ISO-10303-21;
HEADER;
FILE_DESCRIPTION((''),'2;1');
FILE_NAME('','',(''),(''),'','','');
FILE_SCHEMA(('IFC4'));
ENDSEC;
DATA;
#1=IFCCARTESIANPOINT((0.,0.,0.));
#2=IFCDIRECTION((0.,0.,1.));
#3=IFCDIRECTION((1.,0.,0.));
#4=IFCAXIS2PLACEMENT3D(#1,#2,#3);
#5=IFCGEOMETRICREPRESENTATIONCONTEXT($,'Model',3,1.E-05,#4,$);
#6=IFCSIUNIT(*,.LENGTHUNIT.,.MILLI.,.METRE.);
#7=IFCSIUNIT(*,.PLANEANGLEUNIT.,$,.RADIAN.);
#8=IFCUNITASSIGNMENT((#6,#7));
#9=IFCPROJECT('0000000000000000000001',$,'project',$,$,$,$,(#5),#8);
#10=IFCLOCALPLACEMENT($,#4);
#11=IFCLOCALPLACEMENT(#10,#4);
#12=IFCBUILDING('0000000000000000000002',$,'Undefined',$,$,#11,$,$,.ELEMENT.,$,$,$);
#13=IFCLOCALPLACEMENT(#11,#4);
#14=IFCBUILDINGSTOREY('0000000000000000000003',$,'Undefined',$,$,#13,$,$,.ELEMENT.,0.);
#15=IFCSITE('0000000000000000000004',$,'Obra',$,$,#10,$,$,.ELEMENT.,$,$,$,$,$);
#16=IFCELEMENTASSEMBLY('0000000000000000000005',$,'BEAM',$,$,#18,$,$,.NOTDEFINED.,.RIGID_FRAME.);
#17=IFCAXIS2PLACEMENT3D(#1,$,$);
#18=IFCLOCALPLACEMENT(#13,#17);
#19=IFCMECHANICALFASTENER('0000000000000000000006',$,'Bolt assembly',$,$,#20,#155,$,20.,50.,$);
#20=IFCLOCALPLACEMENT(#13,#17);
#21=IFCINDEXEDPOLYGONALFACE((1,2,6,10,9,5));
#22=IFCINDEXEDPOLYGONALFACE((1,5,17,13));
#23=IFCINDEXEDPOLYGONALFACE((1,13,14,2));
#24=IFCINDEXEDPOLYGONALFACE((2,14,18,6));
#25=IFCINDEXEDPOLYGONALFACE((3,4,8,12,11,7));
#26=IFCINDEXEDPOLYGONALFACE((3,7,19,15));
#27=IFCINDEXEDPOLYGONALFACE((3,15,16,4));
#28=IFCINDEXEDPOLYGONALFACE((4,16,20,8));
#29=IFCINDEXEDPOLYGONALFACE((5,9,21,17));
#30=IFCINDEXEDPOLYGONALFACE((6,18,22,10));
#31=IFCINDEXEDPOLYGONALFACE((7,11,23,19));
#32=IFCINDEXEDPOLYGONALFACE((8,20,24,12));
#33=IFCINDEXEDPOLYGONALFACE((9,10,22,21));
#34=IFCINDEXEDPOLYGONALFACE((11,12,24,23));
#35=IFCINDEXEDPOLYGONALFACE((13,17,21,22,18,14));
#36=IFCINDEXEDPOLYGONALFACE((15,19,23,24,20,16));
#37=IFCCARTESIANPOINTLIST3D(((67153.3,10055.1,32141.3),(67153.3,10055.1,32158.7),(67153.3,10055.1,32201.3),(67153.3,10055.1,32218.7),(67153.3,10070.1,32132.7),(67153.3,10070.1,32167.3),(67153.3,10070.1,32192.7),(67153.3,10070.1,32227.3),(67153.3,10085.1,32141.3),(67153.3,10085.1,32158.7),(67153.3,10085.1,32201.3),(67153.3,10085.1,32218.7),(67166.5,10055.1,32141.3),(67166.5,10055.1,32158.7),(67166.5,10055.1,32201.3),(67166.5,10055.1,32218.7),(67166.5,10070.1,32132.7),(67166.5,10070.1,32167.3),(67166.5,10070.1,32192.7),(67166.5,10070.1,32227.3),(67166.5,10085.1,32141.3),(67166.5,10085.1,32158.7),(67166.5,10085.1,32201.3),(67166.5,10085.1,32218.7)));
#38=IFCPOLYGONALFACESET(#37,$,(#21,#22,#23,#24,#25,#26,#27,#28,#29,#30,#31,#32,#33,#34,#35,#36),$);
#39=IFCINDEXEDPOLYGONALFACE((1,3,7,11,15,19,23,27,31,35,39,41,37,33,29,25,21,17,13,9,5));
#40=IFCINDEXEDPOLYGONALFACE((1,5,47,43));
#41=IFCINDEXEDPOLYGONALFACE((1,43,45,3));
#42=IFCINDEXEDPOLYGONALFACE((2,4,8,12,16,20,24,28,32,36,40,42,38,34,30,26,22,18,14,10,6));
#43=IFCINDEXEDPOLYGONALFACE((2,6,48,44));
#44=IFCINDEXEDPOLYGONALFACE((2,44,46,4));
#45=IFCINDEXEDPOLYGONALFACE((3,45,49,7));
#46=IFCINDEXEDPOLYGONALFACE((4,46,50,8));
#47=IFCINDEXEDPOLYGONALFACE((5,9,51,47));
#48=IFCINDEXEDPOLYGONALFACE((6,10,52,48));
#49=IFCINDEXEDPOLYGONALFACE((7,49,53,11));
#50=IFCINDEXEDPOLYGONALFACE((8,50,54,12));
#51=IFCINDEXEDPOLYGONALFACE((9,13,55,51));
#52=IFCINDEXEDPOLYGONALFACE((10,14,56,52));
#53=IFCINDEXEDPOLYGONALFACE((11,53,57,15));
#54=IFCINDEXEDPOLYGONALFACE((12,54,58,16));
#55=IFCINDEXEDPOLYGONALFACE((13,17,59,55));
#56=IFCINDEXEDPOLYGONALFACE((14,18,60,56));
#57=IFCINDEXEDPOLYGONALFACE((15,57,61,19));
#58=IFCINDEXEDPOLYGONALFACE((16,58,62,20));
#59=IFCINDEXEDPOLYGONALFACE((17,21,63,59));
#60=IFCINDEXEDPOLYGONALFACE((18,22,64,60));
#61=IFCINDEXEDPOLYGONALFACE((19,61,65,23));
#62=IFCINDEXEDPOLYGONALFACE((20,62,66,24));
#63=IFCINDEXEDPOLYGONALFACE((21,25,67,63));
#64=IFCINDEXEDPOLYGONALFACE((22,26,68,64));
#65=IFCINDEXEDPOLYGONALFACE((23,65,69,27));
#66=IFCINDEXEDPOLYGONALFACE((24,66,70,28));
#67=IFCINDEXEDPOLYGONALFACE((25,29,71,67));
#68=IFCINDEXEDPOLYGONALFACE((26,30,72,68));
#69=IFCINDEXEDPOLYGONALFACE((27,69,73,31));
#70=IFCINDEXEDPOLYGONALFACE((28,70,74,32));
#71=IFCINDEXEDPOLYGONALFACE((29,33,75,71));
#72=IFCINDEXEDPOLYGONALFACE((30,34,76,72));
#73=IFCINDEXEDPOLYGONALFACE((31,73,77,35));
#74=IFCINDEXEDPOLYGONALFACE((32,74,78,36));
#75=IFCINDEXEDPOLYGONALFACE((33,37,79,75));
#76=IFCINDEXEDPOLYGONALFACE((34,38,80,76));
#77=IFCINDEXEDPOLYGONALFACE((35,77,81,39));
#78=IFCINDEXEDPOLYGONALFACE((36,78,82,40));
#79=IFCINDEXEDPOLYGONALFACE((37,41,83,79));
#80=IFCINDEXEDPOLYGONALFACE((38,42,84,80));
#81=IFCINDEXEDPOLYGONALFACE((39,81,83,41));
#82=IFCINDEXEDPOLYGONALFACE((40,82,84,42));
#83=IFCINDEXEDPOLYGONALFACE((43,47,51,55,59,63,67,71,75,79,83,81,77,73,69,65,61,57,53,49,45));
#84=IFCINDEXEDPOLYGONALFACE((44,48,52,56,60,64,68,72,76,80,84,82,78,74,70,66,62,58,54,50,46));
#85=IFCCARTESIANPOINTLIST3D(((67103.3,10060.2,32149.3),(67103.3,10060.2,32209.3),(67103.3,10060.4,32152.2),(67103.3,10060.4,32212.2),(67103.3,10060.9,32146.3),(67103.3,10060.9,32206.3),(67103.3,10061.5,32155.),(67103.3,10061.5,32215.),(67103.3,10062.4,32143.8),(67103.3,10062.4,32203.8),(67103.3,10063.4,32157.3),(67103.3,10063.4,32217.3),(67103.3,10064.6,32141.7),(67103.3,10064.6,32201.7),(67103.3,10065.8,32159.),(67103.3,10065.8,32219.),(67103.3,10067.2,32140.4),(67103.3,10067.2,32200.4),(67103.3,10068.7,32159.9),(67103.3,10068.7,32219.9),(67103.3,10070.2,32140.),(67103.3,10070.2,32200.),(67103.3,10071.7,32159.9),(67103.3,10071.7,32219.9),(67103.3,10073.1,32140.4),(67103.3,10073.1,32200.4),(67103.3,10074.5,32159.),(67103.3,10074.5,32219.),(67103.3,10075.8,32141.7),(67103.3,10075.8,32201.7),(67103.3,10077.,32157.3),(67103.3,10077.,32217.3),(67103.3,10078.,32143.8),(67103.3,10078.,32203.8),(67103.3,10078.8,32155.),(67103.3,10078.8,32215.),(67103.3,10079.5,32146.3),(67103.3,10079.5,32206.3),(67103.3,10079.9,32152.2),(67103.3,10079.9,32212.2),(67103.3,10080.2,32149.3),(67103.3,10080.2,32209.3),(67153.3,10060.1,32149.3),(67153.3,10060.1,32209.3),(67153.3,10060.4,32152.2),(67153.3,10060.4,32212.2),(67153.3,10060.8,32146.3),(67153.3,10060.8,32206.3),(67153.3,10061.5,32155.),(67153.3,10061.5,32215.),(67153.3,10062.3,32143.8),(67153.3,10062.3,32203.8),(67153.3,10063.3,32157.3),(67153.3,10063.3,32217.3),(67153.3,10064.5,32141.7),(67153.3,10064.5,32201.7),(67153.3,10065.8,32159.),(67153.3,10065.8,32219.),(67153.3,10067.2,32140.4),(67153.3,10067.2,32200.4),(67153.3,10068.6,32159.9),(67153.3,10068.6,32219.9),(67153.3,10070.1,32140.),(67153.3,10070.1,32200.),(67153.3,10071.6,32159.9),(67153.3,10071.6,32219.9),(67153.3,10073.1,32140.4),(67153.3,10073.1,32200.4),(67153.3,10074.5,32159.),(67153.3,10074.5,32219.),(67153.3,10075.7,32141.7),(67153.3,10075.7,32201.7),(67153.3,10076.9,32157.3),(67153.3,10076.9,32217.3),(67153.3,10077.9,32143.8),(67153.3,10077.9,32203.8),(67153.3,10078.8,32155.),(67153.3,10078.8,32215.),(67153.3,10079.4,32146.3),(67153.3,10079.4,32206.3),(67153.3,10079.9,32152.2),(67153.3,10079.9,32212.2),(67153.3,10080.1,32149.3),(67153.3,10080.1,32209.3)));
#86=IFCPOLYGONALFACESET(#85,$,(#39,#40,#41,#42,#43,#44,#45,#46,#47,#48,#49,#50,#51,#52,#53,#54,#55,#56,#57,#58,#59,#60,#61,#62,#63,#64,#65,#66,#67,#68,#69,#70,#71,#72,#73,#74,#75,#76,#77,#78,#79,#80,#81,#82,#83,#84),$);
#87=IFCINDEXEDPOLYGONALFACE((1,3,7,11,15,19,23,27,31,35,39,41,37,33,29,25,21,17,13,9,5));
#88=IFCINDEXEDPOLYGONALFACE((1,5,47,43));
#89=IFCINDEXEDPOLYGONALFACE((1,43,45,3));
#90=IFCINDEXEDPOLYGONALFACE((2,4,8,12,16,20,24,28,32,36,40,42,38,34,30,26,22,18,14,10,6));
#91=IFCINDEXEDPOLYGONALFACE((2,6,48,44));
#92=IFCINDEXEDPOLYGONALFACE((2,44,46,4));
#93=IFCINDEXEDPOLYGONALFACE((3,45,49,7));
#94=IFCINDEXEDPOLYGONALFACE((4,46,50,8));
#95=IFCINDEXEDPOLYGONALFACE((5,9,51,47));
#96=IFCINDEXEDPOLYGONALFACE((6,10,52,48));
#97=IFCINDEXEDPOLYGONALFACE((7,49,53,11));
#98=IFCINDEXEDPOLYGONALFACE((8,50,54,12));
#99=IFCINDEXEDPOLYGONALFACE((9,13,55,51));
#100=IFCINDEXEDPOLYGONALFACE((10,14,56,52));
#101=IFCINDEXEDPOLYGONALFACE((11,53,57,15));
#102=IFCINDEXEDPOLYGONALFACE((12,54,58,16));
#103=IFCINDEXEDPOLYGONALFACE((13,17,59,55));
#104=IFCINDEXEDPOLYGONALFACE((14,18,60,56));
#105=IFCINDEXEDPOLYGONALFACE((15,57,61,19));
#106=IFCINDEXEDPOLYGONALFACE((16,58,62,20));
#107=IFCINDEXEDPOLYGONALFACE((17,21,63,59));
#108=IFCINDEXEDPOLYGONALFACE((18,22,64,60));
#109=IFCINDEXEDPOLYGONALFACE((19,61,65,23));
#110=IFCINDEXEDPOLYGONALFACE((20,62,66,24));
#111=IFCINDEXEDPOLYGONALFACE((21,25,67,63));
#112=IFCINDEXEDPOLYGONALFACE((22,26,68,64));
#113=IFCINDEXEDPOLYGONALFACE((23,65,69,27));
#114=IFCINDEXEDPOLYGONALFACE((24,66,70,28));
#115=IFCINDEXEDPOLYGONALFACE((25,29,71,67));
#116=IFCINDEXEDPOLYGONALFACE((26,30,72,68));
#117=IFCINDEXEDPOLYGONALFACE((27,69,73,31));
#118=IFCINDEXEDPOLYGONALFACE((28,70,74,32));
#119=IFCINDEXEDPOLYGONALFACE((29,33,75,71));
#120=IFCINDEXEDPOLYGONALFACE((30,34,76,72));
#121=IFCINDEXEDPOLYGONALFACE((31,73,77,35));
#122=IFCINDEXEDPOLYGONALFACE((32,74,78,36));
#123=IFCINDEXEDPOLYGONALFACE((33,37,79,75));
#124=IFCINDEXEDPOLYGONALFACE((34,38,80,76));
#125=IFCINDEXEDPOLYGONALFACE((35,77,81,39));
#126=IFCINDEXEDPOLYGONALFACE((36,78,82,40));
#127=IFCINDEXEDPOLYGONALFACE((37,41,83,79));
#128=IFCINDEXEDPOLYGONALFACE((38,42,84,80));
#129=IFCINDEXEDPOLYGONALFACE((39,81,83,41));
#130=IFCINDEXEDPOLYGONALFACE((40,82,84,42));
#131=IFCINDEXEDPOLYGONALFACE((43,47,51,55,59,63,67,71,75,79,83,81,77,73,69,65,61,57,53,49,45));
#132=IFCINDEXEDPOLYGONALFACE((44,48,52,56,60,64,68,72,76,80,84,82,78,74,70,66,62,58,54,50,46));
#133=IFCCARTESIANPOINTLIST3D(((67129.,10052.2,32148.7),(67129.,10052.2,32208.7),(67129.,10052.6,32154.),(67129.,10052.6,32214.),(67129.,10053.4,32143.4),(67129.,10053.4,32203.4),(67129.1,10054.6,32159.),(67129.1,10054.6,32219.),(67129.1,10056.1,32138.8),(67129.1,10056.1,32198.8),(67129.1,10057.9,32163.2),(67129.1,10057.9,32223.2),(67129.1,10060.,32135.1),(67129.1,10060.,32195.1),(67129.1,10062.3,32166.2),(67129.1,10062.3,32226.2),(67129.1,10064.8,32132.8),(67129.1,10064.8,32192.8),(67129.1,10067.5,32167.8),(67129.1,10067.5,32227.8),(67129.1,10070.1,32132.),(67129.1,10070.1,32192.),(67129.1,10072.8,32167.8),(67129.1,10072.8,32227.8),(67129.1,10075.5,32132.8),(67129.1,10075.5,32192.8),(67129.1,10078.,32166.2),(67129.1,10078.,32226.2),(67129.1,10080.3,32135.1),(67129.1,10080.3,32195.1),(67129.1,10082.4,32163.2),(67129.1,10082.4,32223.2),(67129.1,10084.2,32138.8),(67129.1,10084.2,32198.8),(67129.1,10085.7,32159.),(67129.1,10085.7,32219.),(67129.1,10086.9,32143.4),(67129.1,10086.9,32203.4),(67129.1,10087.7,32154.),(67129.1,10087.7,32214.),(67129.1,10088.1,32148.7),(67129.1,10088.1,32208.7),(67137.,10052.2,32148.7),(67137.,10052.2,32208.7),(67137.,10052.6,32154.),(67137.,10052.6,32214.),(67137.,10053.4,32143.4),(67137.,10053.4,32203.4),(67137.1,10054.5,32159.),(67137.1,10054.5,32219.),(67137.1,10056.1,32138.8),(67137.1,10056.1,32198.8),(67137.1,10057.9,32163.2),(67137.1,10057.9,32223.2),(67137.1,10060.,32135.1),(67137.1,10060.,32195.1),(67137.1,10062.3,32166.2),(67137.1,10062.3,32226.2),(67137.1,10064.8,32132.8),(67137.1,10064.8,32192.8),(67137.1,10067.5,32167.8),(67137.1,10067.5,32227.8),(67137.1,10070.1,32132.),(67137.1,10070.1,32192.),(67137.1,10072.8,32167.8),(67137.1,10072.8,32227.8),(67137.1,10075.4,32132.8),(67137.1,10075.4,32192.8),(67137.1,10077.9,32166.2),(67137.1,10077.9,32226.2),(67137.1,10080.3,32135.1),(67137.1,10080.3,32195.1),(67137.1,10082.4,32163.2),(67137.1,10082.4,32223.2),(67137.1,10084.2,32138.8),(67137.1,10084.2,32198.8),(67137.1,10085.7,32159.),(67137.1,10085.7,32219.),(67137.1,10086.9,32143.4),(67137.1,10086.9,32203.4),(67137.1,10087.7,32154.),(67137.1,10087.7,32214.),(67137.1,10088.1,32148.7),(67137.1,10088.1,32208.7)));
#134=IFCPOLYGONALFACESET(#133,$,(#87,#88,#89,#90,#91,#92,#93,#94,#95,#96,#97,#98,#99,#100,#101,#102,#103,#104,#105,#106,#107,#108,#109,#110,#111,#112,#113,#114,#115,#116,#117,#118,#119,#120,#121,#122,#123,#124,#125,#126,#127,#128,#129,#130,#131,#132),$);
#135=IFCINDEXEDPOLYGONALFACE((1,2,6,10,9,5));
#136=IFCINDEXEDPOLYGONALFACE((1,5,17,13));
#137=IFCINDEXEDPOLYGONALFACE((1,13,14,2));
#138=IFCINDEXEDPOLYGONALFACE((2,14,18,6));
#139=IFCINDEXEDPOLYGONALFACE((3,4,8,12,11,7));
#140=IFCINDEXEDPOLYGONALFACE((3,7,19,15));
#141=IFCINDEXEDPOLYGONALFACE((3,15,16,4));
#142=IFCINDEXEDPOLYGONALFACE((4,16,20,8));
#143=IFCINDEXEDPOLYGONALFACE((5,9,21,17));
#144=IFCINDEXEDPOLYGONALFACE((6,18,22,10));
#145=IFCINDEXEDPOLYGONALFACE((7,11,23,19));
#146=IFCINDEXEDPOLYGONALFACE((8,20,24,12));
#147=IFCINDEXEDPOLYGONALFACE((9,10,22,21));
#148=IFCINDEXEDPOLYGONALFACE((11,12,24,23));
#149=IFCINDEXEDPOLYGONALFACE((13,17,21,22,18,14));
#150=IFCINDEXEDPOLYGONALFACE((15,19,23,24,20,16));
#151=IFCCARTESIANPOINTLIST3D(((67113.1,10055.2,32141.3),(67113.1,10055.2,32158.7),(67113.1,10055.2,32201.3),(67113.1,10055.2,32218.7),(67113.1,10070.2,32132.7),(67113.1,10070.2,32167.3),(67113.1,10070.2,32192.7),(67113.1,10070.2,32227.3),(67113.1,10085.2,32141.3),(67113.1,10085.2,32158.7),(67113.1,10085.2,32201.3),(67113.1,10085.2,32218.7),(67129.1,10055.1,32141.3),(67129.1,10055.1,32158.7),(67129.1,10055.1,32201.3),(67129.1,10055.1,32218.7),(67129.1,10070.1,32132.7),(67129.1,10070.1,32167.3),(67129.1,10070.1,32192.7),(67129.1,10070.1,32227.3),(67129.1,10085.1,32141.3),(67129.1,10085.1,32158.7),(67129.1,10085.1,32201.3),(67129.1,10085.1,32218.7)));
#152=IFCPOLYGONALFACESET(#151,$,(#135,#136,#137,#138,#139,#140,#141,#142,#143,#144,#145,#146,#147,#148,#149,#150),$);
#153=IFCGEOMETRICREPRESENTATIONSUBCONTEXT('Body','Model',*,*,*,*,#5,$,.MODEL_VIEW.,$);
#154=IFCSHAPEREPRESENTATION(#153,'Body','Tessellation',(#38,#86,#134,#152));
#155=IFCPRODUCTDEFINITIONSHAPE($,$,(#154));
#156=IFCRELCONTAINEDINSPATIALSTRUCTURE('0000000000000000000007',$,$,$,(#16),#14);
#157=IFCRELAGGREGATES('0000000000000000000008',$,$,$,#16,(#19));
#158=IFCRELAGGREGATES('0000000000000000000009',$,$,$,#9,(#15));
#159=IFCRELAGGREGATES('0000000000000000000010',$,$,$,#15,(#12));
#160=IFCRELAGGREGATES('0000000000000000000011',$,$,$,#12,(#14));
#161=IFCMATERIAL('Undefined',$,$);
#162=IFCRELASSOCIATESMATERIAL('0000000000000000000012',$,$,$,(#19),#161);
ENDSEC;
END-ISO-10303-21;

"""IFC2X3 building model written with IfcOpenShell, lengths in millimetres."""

from ifc_helpers import new_model, si_unit, frame, origin_with_axes, origin_2d_with_axis, place, context, subcontext, project, spatial, polyline, circle, outline, extrude, source, transform, mapped, material, element, aggregate, save


model = new_model("IFC2X3")

# Units and contexts
model_context = context("Model", 3, precision=1e-05, world=origin_with_axes())
body_context = subcontext(model_context, "Body", "Model", "MODEL_VIEW")
ifc_project = project(units=[si_unit("LENGTHUNIT", "METRE", prefix="MILLI"), si_unit("PLANEANGLEUNIT", "RADIAN")], contexts=[model_context])

# Site, building, storey
site_placement = place(None, origin_with_axes())
site = spatial("IfcSite", under=ifc_project, at=site_placement, Name="Obra", CompositionType="ELEMENT")
building_placement = place(site_placement, origin_with_axes())
building = spatial("IfcBuilding", under=site, at=building_placement, Name="Undefined", CompositionType="ELEMENT")
storey_placement = place(building_placement, origin_with_axes())
storey = spatial("IfcBuildingStorey", under=building, at=storey_placement, Name="Undefined", CompositionType="ELEMENT", Elevation=0.0)

# Element assembly
assembly_1_placement = place(storey_placement, origin_with_axes())
assembly_1 = element("IfcElementAssembly", 1, at=assembly_1_placement, inside=storey, Name="BEAM", AssemblyPlace="NOTDEFINED", PredefinedType="RIGID_FRAME")

# Mechanical fastener
ifc_material_1 = material(Name="Undefined")
shared_shape_1 = source(origin_with_axes(), body_context, "Body", "SweptSolid", [
    extrude(outline(polyline([(17.3, 0.0), (8.7, 15.0), (-8.7, 15.0), (-17.3, 0.0), (-8.7, -15.0), (8.7, -15.0), (17.3, 0.0)])), frame((0.0, -26.2, 0.0), z_axis=(0.0, 1.0, 0.0), x_axis=(1.0, 0.0, 0.0)), (0.0, 0.0, 1.0), 13.2),
    extrude(circle(Radius=10.0, at=origin_2d_with_axis()), frame((0.0, -13.0, 0.0), z_axis=(0.0, 1.0, 0.0), x_axis=(1.0, 0.0, 0.0)), (0.0, 0.0, 1.0), 50.0),
    extrude(circle(Radius=18.0, at=origin_2d_with_axis()), frame((0.0, 3.3, 0.0), z_axis=(0.0, 1.0, 0.0), x_axis=(1.0, 0.0, 0.0)), (0.0, 0.0, 1.0), 8.0),
    extrude(outline(polyline([(17.3, 0.0), (8.7, 15.0), (-8.7, 15.0), (-17.3, 0.0), (-8.7, -15.0), (8.7, -15.0), (17.3, 0.0)])), frame((0.0, 11.3, 0.0), z_axis=(0.0, 1.0, 0.0), x_axis=(1.0, 0.0, 0.0)), (0.0, 0.0, 1.0), 16.0),
])
mechanical_fastener_1_placement = place(assembly_1_placement, frame((67140.3, 10030.1, 32250.0), z_axis=(0.001509, 0.999999, 0.0), x_axis=(0.0, 0.0, -1.0)))
mechanical_fastener_1 = element("IfcMechanicalFastener", 2, at=mechanical_fastener_1_placement, material=ifc_material_1, Name="Bolt assembly", NominalDiameter=20.0, NominalLength=50.0, context=body_context, shape_type="MappedRepresentation", body=[
    mapped(shared_shape_1, transform((40.0, 0.0, 40.0))),
    mapped(shared_shape_1, transform((100.0, 0.0, 40.0))),
])
aggregate(assembly_1, [mechanical_fastener_1])

save(model, "model.ifc")
